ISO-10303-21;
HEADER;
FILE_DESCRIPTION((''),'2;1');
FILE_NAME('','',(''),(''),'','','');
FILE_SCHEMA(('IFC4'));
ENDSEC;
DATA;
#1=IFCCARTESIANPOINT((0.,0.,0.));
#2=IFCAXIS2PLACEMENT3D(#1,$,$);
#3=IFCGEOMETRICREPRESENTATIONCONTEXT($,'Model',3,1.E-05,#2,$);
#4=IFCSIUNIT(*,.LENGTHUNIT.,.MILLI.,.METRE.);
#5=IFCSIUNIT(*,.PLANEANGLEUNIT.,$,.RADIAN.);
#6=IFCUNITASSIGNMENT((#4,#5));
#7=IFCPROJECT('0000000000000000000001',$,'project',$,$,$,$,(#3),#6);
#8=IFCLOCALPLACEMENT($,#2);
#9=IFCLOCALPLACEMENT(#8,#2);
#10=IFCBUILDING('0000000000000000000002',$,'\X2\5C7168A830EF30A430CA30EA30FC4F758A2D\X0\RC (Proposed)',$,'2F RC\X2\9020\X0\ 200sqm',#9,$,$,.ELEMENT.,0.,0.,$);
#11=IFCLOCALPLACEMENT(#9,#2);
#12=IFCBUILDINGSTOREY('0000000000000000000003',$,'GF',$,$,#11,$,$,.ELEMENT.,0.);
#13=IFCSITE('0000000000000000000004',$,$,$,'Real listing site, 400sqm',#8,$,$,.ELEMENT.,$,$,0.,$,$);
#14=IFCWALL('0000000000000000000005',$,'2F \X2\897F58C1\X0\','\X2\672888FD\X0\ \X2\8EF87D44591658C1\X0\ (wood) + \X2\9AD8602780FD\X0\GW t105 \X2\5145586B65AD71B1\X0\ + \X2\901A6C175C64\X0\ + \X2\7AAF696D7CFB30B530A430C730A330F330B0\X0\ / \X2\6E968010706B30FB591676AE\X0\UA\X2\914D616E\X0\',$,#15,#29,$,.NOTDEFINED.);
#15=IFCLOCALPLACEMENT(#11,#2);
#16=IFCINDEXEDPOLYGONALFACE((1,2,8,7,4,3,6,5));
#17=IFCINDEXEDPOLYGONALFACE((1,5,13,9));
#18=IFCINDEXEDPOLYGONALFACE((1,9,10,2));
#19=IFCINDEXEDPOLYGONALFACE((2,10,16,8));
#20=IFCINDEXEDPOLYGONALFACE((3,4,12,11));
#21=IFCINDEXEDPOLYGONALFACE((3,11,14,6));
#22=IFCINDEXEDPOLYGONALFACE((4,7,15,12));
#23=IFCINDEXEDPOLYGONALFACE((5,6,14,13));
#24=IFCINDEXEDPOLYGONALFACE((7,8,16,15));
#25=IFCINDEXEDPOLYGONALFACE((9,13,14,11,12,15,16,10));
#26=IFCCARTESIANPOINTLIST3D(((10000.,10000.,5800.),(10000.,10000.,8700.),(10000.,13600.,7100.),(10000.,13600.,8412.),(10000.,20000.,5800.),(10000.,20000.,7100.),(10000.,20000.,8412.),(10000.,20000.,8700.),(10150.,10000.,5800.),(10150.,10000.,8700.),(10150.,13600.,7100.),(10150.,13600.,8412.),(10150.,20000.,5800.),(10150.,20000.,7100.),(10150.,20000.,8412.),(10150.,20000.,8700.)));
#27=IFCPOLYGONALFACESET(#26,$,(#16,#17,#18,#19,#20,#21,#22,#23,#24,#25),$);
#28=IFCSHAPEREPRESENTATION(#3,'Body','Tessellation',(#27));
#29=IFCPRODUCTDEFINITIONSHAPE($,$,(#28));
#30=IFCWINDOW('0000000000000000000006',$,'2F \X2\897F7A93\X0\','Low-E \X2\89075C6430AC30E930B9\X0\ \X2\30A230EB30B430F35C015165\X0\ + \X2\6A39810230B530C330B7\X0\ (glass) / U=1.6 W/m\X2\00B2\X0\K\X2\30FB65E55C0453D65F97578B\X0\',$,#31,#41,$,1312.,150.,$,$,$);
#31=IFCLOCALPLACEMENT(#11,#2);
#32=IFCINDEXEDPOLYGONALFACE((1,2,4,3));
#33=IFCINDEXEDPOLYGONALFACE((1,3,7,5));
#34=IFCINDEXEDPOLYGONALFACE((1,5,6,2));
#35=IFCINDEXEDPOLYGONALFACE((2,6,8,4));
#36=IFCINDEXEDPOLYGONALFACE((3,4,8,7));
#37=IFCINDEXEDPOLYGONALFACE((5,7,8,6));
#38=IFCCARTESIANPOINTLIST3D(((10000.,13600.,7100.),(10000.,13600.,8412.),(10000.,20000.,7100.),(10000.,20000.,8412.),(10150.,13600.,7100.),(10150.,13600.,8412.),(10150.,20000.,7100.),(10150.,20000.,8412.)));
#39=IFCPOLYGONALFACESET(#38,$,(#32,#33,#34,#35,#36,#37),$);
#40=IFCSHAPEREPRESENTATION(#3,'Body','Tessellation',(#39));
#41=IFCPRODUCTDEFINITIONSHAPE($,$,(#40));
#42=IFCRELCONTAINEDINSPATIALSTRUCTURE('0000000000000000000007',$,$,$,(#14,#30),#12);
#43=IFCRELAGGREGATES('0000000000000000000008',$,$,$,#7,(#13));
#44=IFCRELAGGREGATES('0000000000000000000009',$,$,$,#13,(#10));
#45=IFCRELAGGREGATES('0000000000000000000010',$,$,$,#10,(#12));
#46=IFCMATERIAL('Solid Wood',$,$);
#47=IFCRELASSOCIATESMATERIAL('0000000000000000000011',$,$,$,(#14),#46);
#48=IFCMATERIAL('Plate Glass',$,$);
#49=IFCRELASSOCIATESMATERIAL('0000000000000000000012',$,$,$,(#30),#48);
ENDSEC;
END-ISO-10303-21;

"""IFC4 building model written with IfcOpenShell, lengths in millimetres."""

from ifc_helpers import new_model, si_unit, frame, frame_2d, origin, place, context, project, spatial, rectangle, extrude, material, element, fill, save


model = new_model("IFC4")

# Units and contexts
model_context = context("Model", 3, precision=1e-05, world=origin())
ifc_project = project(units=[si_unit("LENGTHUNIT", "METRE", prefix="MILLI"), si_unit("PLANEANGLEUNIT", "RADIAN")], contexts=[model_context])

# Site, building, storey
site_placement = place(None, origin())
site = spatial("IfcSite", under=ifc_project, at=site_placement, ObjectType="Real listing site, 400sqm", CompositionType="ELEMENT", RefElevation=0.0)
building_placement = place(site_placement, origin())
building = spatial("IfcBuilding", under=site, at=building_placement, Name="山梨ワイナリー併設RC (Proposed)", ObjectType="2F RC造 200sqm", CompositionType="ELEMENT", ElevationOfRefHeight=0.0, ElevationOfTerrain=0.0)
storey_placement = place(building_placement, origin())
storey = spatial("IfcBuildingStorey", under=building, at=storey_placement, Name="GF", CompositionType="ELEMENT", Elevation=0.0)

# Shared definitions
ifc_material_1 = material(Name="Solid Wood")

# Shared definitions
ifc_material_2 = material(Name="Plate Glass")

# Wall, opening, window
wall_1_placement = place(storey_placement, frame((5000.0, 5000.0, 2900.0)))
wall_1 = element("IfcWall", 1, at=wall_1_placement, inside=storey, material=ifc_material_1, Name="2F 西壁", Description="木製 軸組外壁 (wood) + 高性能GW t105 充填断熱 + 通気層 + 窯業系サイディング / 準耐火・外皮UA配慮", PredefinedType="NOTDEFINED", context=model_context, shape_type="SweptSolid", body=[
    extrude(rectangle(XDim=150.0, YDim=10000.0, at=frame_2d((75.0, 5000.0))), frame((5000.0, 5000.0, 2900.0)), (0.0, 0.0, 1.0), 2900.0),
])
opening_1_placement = place(storey_placement, frame((5000.0, 6800.0, 3550.0)))
opening_1 = element("IfcOpeningElement", 2, at=opening_1_placement, cuts=wall_1, PredefinedType="NOTDEFINED", context=model_context, shape_type="SweptSolid", body=[
    extrude(rectangle(XDim=150.0, YDim=6400.0, at=frame_2d((75.0, 3200.0))), frame((5000.0, 6800.0, 3550.0)), (0.0, 0.0, 1.0), 1312.0),
])
window_1_placement = place(storey_placement, frame((5000.0, 6800.0, 3550.0)))
window_1 = element("IfcWindow", 3, at=window_1_placement, inside=storey, material=ifc_material_2, Name="2F 西窓", Description="Low-E 複層ガラス アルゴン封入 + 樹脂サッシ (glass) / U=1.6 W/m²K・日射取得型", OverallHeight=1312.0, OverallWidth=150.0, context=model_context, shape_type="SweptSolid", body=[
    extrude(rectangle(XDim=150.0, YDim=6400.0, at=frame_2d((75.0, 3200.0))), frame((5000.0, 6800.0, 3550.0)), (0.0, 0.0, 1.0), 1312.0),
])
fill(opening_1, window_1)

save(model, "model.ifc")
